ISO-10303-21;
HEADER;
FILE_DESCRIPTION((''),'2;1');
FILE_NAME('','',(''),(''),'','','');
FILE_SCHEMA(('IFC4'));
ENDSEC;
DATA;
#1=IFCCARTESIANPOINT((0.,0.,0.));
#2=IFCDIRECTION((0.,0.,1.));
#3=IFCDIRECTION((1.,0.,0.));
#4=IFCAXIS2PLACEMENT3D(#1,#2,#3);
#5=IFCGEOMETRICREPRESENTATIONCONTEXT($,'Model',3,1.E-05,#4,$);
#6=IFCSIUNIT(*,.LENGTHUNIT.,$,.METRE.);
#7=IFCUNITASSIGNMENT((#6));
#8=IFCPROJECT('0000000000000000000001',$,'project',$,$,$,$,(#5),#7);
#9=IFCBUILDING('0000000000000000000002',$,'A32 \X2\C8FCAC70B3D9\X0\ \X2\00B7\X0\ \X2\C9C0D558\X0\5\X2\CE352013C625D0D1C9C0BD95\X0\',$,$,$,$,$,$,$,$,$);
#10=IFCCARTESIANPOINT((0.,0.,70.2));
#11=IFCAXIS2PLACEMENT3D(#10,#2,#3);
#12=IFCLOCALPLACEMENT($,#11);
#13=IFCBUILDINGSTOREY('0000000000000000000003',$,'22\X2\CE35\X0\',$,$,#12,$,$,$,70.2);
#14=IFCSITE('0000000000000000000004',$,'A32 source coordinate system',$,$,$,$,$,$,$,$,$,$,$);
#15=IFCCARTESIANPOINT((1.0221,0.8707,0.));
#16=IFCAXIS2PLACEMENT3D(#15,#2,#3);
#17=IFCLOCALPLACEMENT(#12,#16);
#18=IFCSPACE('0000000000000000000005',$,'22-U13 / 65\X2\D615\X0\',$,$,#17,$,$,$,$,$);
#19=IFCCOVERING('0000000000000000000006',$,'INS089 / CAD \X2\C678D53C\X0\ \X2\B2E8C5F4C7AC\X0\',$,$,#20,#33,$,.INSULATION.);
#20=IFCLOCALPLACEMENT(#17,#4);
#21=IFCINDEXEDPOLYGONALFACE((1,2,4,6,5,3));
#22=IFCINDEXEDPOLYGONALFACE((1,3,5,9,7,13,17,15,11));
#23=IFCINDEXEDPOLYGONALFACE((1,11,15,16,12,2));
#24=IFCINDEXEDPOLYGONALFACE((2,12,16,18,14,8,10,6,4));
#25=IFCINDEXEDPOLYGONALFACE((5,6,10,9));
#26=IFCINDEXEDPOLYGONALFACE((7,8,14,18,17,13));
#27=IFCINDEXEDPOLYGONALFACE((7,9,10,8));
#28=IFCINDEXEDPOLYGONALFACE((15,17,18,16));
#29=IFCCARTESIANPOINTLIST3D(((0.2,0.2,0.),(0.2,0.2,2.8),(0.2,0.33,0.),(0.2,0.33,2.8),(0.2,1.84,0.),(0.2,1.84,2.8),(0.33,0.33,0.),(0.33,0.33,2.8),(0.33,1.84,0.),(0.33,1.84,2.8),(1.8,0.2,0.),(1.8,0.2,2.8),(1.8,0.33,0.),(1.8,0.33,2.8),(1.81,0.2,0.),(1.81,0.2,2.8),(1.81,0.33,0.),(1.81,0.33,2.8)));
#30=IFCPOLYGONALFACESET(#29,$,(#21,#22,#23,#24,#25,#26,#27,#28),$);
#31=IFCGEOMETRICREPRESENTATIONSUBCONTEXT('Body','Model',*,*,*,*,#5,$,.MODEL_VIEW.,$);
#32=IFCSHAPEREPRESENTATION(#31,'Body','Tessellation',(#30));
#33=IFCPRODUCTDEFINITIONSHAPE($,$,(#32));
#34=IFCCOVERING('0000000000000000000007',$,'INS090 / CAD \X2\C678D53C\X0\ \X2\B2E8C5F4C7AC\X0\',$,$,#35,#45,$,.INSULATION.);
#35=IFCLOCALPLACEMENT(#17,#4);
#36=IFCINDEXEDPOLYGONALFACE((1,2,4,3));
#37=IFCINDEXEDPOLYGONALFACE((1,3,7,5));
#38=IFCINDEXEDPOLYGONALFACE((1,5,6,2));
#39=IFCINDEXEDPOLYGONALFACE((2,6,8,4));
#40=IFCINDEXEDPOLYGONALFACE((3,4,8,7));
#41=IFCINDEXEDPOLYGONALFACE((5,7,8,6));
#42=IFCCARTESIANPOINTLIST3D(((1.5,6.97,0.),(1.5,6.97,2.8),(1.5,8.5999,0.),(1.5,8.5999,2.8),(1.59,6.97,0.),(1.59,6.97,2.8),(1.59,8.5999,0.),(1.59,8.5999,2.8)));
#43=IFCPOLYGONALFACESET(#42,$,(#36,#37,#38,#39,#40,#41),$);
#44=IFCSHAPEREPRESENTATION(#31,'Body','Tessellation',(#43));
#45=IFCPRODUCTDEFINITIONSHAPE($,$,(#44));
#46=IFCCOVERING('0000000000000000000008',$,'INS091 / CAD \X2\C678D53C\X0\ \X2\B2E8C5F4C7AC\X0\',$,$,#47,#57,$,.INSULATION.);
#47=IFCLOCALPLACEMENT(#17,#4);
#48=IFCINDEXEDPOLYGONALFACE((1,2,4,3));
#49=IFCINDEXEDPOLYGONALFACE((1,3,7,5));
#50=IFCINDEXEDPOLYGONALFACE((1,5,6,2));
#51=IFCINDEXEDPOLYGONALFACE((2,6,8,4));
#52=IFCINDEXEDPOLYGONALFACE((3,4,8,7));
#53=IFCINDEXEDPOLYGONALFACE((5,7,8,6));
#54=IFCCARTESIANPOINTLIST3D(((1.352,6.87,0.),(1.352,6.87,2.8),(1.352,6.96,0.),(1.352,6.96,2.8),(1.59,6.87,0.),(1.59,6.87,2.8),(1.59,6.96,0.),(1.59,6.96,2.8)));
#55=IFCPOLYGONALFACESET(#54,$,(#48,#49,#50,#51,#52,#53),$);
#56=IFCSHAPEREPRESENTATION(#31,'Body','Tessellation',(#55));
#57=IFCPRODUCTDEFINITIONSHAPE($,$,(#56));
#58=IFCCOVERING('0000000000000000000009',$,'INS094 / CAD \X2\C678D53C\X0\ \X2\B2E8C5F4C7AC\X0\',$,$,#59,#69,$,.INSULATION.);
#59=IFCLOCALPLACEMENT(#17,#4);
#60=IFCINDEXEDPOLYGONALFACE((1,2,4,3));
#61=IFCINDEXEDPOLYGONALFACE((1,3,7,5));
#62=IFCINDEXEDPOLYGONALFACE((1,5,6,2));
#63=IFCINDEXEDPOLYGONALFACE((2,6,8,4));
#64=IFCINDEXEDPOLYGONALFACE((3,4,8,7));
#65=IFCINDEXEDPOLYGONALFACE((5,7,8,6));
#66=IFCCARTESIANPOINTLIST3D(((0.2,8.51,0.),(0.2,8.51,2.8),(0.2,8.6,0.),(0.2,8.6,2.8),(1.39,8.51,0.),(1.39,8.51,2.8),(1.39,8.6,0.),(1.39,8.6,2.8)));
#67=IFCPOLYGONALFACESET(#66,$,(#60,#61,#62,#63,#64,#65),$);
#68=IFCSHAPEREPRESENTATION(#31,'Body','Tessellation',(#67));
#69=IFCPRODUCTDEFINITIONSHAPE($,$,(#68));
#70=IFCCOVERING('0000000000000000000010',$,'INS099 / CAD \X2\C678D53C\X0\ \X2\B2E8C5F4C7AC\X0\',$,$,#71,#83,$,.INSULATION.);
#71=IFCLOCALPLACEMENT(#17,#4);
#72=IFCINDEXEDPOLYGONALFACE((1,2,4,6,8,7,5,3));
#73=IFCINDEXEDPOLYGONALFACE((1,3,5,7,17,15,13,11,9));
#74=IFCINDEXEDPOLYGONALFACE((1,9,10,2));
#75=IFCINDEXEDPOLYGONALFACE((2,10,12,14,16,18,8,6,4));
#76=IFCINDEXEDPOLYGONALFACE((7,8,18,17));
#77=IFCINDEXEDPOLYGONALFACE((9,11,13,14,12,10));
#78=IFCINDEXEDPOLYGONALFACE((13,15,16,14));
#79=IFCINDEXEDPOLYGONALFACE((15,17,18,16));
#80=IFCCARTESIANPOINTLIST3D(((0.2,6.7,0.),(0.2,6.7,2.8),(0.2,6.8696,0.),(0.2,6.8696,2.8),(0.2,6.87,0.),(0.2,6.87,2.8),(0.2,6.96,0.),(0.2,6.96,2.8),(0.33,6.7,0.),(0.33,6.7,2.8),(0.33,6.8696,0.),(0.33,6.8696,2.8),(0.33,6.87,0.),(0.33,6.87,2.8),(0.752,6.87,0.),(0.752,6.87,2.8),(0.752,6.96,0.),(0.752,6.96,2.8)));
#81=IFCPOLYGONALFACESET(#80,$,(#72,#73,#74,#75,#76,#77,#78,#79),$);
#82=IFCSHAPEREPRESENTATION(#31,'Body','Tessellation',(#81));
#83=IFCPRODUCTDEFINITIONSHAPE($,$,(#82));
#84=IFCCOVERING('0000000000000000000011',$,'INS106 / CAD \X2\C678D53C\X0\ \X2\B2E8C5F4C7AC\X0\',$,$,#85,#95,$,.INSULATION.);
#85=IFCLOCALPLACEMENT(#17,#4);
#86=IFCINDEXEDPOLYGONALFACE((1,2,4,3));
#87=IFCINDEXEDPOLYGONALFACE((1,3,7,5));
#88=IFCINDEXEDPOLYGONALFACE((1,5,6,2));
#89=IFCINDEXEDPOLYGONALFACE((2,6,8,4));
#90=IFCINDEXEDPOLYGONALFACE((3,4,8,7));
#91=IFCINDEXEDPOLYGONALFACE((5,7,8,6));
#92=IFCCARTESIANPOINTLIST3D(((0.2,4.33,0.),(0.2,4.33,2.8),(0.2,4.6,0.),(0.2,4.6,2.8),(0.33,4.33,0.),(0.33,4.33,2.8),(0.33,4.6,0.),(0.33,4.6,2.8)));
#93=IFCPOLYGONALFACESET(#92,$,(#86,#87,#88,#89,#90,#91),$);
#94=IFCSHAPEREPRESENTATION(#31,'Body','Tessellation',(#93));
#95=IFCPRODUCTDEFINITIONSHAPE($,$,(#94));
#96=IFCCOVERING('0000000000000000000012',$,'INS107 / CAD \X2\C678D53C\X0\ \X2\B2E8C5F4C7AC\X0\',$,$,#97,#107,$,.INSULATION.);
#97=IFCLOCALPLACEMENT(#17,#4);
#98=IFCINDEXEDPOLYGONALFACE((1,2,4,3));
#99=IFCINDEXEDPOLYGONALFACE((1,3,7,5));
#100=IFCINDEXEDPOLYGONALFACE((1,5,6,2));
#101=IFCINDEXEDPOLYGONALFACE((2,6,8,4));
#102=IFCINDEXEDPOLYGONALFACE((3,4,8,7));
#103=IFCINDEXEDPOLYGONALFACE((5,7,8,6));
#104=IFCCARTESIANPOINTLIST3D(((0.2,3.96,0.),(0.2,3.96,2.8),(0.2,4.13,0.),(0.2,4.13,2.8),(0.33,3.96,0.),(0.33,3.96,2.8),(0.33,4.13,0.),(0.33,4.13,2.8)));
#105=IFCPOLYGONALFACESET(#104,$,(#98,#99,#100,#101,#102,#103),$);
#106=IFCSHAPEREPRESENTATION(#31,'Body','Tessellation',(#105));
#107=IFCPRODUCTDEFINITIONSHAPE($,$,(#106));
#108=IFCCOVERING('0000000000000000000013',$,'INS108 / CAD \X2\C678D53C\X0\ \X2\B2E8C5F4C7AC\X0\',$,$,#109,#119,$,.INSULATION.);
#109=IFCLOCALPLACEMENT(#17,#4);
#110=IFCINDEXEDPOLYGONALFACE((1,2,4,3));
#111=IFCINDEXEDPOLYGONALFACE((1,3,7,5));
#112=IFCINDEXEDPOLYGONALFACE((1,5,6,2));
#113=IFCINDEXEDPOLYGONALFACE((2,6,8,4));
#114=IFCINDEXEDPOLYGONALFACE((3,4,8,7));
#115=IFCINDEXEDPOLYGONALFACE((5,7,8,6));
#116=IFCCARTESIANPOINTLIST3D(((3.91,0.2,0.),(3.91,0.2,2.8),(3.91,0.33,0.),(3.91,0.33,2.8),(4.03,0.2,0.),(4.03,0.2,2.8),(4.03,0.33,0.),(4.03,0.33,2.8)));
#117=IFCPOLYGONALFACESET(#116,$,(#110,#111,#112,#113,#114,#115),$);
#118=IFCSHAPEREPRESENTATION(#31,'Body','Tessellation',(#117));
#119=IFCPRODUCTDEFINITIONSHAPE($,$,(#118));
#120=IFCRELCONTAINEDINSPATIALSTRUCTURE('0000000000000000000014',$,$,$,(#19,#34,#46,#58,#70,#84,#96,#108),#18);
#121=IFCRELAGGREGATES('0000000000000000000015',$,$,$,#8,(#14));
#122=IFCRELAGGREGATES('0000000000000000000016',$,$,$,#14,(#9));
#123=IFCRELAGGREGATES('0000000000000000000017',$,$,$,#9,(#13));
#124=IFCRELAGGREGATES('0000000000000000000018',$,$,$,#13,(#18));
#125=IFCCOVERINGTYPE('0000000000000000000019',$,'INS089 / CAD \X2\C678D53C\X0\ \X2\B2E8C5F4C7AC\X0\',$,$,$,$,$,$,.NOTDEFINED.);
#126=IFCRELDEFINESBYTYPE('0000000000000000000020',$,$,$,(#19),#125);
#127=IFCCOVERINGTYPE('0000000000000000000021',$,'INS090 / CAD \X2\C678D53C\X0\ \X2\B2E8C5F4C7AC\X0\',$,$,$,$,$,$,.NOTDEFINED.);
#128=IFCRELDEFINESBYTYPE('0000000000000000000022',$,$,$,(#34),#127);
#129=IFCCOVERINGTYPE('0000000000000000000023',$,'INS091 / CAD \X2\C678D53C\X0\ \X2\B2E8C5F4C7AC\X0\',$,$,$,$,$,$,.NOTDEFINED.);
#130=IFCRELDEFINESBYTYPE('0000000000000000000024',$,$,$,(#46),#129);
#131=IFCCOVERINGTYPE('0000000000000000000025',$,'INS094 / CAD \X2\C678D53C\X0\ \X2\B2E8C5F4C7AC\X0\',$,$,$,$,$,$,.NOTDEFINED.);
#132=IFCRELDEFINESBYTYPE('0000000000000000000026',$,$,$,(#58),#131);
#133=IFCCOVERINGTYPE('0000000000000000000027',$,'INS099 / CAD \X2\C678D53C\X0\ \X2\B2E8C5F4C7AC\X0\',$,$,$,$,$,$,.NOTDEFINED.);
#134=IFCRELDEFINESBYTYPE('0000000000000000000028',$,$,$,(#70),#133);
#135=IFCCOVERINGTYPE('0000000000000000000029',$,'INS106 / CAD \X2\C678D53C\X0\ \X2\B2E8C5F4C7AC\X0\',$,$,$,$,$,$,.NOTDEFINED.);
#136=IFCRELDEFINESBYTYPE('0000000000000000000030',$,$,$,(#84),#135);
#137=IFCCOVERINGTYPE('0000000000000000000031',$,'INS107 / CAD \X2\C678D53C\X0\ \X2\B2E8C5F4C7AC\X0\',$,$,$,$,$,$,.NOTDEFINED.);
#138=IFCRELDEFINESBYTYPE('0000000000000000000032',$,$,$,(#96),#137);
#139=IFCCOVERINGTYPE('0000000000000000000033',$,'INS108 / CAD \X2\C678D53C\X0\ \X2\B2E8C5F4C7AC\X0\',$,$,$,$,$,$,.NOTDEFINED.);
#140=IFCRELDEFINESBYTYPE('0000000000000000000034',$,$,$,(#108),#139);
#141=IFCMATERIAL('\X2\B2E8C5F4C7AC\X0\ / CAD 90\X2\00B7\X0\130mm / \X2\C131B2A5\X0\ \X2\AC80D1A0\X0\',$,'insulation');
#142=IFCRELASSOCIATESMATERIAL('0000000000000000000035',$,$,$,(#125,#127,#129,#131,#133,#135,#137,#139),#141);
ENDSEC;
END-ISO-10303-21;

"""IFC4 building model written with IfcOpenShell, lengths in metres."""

from ifc_helpers import new_model, si_unit, frame, origin, origin_with_axes, place, context, subcontext, project, spatial, polyline, outline, extrude, source, transform, mapped, material, type_object, type_shapes, element, save


model = new_model("IFC4")

# Units and contexts
model_context = context("Model", 3, precision=1e-05, world=origin_with_axes())
body_context = subcontext(model_context, "Body", "Model", "MODEL_VIEW")
ifc_project = project(units=[si_unit("LENGTHUNIT", "METRE")], contexts=[model_context])

# Site, building, storey
site = spatial("IfcSite", under=ifc_project, Name="A32 source coordinate system")
building = spatial("IfcBuilding", under=site, Name="A32 주거동 · 지하5층–옥탑지붕")
storey_placement = place(None, frame((0.0, 0.0, 70.2), z_axis=(0.0, 0.0, 1.0), x_axis=(1.0, 0.0, 0.0)))
storey = spatial("IfcBuildingStorey", under=building, at=storey_placement, Name="22층", Elevation=70.2)

# Shared definitions
space_placement = place(storey_placement, frame((1.0221, 0.8707, 0.0), z_axis=(0.0, 0.0, 1.0), x_axis=(1.0, 0.0, 0.0)))
space = spatial("IfcSpace", under=storey, at=space_placement, Name="22-U13 / 65형")

# Coverings
ifc_material = material(Name="단열재 / CAD 90·130mm / 성능 검토", Category="insulation")
covering_type_1 = type_object("IfcCoveringType", Name="INS089 / CAD 외피 단열재", PredefinedType="NOTDEFINED", material=ifc_material)
shared_shape_1 = source(origin(), body_context, "Body", "SweptSolid", [
    extrude(outline(polyline([(0.2, 0.33), (0.2, 1.84), (0.33, 1.84), (0.33, 0.33), (1.8, 0.33), (1.81, 0.33), (1.81, 0.2), (1.8, 0.2), (0.2, 0.2), (0.2, 0.33)])), origin(), (0.0, 0.0, 1.0), 2.8),
])
type_shapes(covering_type_1, [shared_shape_1])
covering_1_placement = place(space_placement, origin_with_axes())
element("IfcCovering", 1, at=covering_1_placement, inside=space, type_object=covering_type_1, Name="INS089 / CAD 외피 단열재", PredefinedType="INSULATION", context=body_context, shape_type="MappedRepresentation", body=[
    mapped(shared_shape_1, transform((0.0, 0.0, 0.0), scale=1.0)),
])
covering_type_2 = type_object("IfcCoveringType", Name="INS090 / CAD 외피 단열재", PredefinedType="NOTDEFINED", material=ifc_material)
shared_shape_2 = source(origin(), body_context, "Body", "SweptSolid", [
    extrude(outline(polyline([(1.59, 6.97), (1.5, 6.97), (1.5, 8.5999), (1.59, 8.5999), (1.59, 6.97)])), origin(), (0.0, 0.0, 1.0), 2.8),
])
type_shapes(covering_type_2, [shared_shape_2])
covering_2_placement = place(space_placement, origin_with_axes())
element("IfcCovering", 2, at=covering_2_placement, inside=space, type_object=covering_type_2, Name="INS090 / CAD 외피 단열재", PredefinedType="INSULATION", context=body_context, shape_type="MappedRepresentation", body=[
    mapped(shared_shape_2, transform((0.0, 0.0, 0.0), scale=1.0)),
])
covering_type_3 = type_object("IfcCoveringType", Name="INS091 / CAD 외피 단열재", PredefinedType="NOTDEFINED", material=ifc_material)
shared_shape_3 = source(origin(), body_context, "Body", "SweptSolid", [
    extrude(outline(polyline([(1.59, 6.96), (1.59, 6.87), (1.352, 6.87), (1.352, 6.96), (1.59, 6.96)])), origin(), (0.0, 0.0, 1.0), 2.8),
])
type_shapes(covering_type_3, [shared_shape_3])
covering_3_placement = place(space_placement, origin_with_axes())
element("IfcCovering", 3, at=covering_3_placement, inside=space, type_object=covering_type_3, Name="INS091 / CAD 외피 단열재", PredefinedType="INSULATION", context=body_context, shape_type="MappedRepresentation", body=[
    mapped(shared_shape_3, transform((0.0, 0.0, 0.0), scale=1.0)),
])
covering_type_4 = type_object("IfcCoveringType", Name="INS094 / CAD 외피 단열재", PredefinedType="NOTDEFINED", material=ifc_material)
shared_shape_4 = source(origin(), body_context, "Body", "SweptSolid", [
    extrude(outline(polyline([(1.39, 8.51), (0.2, 8.51), (0.2, 8.6), (1.39, 8.6), (1.39, 8.51)])), origin(), (0.0, 0.0, 1.0), 2.8),
])
type_shapes(covering_type_4, [shared_shape_4])
covering_4_placement = place(space_placement, origin_with_axes())
element("IfcCovering", 4, at=covering_4_placement, inside=space, type_object=covering_type_4, Name="INS094 / CAD 외피 단열재", PredefinedType="INSULATION", context=body_context, shape_type="MappedRepresentation", body=[
    mapped(shared_shape_4, transform((0.0, 0.0, 0.0), scale=1.0)),
])
covering_type_5 = type_object("IfcCoveringType", Name="INS099 / CAD 외피 단열재", PredefinedType="NOTDEFINED", material=ifc_material)
shared_shape_5 = source(origin(), body_context, "Body", "SweptSolid", [
    extrude(outline(polyline([(0.2, 6.8696), (0.2, 6.87), (0.2, 6.96), (0.752, 6.96), (0.752, 6.87), (0.33, 6.87), (0.33, 6.8696), (0.33, 6.7), (0.2, 6.7), (0.2, 6.8696)])), origin(), (0.0, 0.0, 1.0), 2.8),
])
type_shapes(covering_type_5, [shared_shape_5])
covering_5_placement = place(space_placement, origin_with_axes())
element("IfcCovering", 5, at=covering_5_placement, inside=space, type_object=covering_type_5, Name="INS099 / CAD 외피 단열재", PredefinedType="INSULATION", context=body_context, shape_type="MappedRepresentation", body=[
    mapped(shared_shape_5, transform((0.0, 0.0, 0.0), scale=1.0)),
])
covering_type_6 = type_object("IfcCoveringType", Name="INS106 / CAD 외피 단열재", PredefinedType="NOTDEFINED", material=ifc_material)
shared_shape_6 = source(origin(), body_context, "Body", "SweptSolid", [
    extrude(outline(polyline([(0.33, 4.6), (0.33, 4.33), (0.2, 4.33), (0.2, 4.6), (0.33, 4.6)])), origin(), (0.0, 0.0, 1.0), 2.8),
])
type_shapes(covering_type_6, [shared_shape_6])
covering_6_placement = place(space_placement, origin_with_axes())
element("IfcCovering", 6, at=covering_6_placement, inside=space, type_object=covering_type_6, Name="INS106 / CAD 외피 단열재", PredefinedType="INSULATION", context=body_context, shape_type="MappedRepresentation", body=[
    mapped(shared_shape_6, transform((0.0, 0.0, 0.0), scale=1.0)),
])
covering_type_7 = type_object("IfcCoveringType", Name="INS107 / CAD 외피 단열재", PredefinedType="NOTDEFINED", material=ifc_material)
shared_shape_7 = source(origin(), body_context, "Body", "SweptSolid", [
    extrude(outline(polyline([(0.33, 3.96), (0.2, 3.96), (0.2, 4.13), (0.33, 4.13), (0.33, 3.96)])), origin(), (0.0, 0.0, 1.0), 2.8),
])
type_shapes(covering_type_7, [shared_shape_7])
covering_7_placement = place(space_placement, origin_with_axes())
element("IfcCovering", 7, at=covering_7_placement, inside=space, type_object=covering_type_7, Name="INS107 / CAD 외피 단열재", PredefinedType="INSULATION", context=body_context, shape_type="MappedRepresentation", body=[
    mapped(shared_shape_7, transform((0.0, 0.0, 0.0), scale=1.0)),
])
covering_type_8 = type_object("IfcCoveringType", Name="INS108 / CAD 외피 단열재", PredefinedType="NOTDEFINED", material=ifc_material)
shared_shape_8 = source(origin(), body_context, "Body", "SweptSolid", [
    extrude(outline(polyline([(4.03, 0.2), (3.91, 0.2), (3.91, 0.33), (4.03, 0.33), (4.03, 0.2)])), origin(), (0.0, 0.0, 1.0), 2.8),
])
type_shapes(covering_type_8, [shared_shape_8])
covering_8_placement = place(space_placement, origin_with_axes())
element("IfcCovering", 8, at=covering_8_placement, inside=space, type_object=covering_type_8, Name="INS108 / CAD 외피 단열재", PredefinedType="INSULATION", context=body_context, shape_type="MappedRepresentation", body=[
    mapped(shared_shape_8, transform((0.0, 0.0, 0.0), scale=1.0)),
])

save(model, "model.ifc")
